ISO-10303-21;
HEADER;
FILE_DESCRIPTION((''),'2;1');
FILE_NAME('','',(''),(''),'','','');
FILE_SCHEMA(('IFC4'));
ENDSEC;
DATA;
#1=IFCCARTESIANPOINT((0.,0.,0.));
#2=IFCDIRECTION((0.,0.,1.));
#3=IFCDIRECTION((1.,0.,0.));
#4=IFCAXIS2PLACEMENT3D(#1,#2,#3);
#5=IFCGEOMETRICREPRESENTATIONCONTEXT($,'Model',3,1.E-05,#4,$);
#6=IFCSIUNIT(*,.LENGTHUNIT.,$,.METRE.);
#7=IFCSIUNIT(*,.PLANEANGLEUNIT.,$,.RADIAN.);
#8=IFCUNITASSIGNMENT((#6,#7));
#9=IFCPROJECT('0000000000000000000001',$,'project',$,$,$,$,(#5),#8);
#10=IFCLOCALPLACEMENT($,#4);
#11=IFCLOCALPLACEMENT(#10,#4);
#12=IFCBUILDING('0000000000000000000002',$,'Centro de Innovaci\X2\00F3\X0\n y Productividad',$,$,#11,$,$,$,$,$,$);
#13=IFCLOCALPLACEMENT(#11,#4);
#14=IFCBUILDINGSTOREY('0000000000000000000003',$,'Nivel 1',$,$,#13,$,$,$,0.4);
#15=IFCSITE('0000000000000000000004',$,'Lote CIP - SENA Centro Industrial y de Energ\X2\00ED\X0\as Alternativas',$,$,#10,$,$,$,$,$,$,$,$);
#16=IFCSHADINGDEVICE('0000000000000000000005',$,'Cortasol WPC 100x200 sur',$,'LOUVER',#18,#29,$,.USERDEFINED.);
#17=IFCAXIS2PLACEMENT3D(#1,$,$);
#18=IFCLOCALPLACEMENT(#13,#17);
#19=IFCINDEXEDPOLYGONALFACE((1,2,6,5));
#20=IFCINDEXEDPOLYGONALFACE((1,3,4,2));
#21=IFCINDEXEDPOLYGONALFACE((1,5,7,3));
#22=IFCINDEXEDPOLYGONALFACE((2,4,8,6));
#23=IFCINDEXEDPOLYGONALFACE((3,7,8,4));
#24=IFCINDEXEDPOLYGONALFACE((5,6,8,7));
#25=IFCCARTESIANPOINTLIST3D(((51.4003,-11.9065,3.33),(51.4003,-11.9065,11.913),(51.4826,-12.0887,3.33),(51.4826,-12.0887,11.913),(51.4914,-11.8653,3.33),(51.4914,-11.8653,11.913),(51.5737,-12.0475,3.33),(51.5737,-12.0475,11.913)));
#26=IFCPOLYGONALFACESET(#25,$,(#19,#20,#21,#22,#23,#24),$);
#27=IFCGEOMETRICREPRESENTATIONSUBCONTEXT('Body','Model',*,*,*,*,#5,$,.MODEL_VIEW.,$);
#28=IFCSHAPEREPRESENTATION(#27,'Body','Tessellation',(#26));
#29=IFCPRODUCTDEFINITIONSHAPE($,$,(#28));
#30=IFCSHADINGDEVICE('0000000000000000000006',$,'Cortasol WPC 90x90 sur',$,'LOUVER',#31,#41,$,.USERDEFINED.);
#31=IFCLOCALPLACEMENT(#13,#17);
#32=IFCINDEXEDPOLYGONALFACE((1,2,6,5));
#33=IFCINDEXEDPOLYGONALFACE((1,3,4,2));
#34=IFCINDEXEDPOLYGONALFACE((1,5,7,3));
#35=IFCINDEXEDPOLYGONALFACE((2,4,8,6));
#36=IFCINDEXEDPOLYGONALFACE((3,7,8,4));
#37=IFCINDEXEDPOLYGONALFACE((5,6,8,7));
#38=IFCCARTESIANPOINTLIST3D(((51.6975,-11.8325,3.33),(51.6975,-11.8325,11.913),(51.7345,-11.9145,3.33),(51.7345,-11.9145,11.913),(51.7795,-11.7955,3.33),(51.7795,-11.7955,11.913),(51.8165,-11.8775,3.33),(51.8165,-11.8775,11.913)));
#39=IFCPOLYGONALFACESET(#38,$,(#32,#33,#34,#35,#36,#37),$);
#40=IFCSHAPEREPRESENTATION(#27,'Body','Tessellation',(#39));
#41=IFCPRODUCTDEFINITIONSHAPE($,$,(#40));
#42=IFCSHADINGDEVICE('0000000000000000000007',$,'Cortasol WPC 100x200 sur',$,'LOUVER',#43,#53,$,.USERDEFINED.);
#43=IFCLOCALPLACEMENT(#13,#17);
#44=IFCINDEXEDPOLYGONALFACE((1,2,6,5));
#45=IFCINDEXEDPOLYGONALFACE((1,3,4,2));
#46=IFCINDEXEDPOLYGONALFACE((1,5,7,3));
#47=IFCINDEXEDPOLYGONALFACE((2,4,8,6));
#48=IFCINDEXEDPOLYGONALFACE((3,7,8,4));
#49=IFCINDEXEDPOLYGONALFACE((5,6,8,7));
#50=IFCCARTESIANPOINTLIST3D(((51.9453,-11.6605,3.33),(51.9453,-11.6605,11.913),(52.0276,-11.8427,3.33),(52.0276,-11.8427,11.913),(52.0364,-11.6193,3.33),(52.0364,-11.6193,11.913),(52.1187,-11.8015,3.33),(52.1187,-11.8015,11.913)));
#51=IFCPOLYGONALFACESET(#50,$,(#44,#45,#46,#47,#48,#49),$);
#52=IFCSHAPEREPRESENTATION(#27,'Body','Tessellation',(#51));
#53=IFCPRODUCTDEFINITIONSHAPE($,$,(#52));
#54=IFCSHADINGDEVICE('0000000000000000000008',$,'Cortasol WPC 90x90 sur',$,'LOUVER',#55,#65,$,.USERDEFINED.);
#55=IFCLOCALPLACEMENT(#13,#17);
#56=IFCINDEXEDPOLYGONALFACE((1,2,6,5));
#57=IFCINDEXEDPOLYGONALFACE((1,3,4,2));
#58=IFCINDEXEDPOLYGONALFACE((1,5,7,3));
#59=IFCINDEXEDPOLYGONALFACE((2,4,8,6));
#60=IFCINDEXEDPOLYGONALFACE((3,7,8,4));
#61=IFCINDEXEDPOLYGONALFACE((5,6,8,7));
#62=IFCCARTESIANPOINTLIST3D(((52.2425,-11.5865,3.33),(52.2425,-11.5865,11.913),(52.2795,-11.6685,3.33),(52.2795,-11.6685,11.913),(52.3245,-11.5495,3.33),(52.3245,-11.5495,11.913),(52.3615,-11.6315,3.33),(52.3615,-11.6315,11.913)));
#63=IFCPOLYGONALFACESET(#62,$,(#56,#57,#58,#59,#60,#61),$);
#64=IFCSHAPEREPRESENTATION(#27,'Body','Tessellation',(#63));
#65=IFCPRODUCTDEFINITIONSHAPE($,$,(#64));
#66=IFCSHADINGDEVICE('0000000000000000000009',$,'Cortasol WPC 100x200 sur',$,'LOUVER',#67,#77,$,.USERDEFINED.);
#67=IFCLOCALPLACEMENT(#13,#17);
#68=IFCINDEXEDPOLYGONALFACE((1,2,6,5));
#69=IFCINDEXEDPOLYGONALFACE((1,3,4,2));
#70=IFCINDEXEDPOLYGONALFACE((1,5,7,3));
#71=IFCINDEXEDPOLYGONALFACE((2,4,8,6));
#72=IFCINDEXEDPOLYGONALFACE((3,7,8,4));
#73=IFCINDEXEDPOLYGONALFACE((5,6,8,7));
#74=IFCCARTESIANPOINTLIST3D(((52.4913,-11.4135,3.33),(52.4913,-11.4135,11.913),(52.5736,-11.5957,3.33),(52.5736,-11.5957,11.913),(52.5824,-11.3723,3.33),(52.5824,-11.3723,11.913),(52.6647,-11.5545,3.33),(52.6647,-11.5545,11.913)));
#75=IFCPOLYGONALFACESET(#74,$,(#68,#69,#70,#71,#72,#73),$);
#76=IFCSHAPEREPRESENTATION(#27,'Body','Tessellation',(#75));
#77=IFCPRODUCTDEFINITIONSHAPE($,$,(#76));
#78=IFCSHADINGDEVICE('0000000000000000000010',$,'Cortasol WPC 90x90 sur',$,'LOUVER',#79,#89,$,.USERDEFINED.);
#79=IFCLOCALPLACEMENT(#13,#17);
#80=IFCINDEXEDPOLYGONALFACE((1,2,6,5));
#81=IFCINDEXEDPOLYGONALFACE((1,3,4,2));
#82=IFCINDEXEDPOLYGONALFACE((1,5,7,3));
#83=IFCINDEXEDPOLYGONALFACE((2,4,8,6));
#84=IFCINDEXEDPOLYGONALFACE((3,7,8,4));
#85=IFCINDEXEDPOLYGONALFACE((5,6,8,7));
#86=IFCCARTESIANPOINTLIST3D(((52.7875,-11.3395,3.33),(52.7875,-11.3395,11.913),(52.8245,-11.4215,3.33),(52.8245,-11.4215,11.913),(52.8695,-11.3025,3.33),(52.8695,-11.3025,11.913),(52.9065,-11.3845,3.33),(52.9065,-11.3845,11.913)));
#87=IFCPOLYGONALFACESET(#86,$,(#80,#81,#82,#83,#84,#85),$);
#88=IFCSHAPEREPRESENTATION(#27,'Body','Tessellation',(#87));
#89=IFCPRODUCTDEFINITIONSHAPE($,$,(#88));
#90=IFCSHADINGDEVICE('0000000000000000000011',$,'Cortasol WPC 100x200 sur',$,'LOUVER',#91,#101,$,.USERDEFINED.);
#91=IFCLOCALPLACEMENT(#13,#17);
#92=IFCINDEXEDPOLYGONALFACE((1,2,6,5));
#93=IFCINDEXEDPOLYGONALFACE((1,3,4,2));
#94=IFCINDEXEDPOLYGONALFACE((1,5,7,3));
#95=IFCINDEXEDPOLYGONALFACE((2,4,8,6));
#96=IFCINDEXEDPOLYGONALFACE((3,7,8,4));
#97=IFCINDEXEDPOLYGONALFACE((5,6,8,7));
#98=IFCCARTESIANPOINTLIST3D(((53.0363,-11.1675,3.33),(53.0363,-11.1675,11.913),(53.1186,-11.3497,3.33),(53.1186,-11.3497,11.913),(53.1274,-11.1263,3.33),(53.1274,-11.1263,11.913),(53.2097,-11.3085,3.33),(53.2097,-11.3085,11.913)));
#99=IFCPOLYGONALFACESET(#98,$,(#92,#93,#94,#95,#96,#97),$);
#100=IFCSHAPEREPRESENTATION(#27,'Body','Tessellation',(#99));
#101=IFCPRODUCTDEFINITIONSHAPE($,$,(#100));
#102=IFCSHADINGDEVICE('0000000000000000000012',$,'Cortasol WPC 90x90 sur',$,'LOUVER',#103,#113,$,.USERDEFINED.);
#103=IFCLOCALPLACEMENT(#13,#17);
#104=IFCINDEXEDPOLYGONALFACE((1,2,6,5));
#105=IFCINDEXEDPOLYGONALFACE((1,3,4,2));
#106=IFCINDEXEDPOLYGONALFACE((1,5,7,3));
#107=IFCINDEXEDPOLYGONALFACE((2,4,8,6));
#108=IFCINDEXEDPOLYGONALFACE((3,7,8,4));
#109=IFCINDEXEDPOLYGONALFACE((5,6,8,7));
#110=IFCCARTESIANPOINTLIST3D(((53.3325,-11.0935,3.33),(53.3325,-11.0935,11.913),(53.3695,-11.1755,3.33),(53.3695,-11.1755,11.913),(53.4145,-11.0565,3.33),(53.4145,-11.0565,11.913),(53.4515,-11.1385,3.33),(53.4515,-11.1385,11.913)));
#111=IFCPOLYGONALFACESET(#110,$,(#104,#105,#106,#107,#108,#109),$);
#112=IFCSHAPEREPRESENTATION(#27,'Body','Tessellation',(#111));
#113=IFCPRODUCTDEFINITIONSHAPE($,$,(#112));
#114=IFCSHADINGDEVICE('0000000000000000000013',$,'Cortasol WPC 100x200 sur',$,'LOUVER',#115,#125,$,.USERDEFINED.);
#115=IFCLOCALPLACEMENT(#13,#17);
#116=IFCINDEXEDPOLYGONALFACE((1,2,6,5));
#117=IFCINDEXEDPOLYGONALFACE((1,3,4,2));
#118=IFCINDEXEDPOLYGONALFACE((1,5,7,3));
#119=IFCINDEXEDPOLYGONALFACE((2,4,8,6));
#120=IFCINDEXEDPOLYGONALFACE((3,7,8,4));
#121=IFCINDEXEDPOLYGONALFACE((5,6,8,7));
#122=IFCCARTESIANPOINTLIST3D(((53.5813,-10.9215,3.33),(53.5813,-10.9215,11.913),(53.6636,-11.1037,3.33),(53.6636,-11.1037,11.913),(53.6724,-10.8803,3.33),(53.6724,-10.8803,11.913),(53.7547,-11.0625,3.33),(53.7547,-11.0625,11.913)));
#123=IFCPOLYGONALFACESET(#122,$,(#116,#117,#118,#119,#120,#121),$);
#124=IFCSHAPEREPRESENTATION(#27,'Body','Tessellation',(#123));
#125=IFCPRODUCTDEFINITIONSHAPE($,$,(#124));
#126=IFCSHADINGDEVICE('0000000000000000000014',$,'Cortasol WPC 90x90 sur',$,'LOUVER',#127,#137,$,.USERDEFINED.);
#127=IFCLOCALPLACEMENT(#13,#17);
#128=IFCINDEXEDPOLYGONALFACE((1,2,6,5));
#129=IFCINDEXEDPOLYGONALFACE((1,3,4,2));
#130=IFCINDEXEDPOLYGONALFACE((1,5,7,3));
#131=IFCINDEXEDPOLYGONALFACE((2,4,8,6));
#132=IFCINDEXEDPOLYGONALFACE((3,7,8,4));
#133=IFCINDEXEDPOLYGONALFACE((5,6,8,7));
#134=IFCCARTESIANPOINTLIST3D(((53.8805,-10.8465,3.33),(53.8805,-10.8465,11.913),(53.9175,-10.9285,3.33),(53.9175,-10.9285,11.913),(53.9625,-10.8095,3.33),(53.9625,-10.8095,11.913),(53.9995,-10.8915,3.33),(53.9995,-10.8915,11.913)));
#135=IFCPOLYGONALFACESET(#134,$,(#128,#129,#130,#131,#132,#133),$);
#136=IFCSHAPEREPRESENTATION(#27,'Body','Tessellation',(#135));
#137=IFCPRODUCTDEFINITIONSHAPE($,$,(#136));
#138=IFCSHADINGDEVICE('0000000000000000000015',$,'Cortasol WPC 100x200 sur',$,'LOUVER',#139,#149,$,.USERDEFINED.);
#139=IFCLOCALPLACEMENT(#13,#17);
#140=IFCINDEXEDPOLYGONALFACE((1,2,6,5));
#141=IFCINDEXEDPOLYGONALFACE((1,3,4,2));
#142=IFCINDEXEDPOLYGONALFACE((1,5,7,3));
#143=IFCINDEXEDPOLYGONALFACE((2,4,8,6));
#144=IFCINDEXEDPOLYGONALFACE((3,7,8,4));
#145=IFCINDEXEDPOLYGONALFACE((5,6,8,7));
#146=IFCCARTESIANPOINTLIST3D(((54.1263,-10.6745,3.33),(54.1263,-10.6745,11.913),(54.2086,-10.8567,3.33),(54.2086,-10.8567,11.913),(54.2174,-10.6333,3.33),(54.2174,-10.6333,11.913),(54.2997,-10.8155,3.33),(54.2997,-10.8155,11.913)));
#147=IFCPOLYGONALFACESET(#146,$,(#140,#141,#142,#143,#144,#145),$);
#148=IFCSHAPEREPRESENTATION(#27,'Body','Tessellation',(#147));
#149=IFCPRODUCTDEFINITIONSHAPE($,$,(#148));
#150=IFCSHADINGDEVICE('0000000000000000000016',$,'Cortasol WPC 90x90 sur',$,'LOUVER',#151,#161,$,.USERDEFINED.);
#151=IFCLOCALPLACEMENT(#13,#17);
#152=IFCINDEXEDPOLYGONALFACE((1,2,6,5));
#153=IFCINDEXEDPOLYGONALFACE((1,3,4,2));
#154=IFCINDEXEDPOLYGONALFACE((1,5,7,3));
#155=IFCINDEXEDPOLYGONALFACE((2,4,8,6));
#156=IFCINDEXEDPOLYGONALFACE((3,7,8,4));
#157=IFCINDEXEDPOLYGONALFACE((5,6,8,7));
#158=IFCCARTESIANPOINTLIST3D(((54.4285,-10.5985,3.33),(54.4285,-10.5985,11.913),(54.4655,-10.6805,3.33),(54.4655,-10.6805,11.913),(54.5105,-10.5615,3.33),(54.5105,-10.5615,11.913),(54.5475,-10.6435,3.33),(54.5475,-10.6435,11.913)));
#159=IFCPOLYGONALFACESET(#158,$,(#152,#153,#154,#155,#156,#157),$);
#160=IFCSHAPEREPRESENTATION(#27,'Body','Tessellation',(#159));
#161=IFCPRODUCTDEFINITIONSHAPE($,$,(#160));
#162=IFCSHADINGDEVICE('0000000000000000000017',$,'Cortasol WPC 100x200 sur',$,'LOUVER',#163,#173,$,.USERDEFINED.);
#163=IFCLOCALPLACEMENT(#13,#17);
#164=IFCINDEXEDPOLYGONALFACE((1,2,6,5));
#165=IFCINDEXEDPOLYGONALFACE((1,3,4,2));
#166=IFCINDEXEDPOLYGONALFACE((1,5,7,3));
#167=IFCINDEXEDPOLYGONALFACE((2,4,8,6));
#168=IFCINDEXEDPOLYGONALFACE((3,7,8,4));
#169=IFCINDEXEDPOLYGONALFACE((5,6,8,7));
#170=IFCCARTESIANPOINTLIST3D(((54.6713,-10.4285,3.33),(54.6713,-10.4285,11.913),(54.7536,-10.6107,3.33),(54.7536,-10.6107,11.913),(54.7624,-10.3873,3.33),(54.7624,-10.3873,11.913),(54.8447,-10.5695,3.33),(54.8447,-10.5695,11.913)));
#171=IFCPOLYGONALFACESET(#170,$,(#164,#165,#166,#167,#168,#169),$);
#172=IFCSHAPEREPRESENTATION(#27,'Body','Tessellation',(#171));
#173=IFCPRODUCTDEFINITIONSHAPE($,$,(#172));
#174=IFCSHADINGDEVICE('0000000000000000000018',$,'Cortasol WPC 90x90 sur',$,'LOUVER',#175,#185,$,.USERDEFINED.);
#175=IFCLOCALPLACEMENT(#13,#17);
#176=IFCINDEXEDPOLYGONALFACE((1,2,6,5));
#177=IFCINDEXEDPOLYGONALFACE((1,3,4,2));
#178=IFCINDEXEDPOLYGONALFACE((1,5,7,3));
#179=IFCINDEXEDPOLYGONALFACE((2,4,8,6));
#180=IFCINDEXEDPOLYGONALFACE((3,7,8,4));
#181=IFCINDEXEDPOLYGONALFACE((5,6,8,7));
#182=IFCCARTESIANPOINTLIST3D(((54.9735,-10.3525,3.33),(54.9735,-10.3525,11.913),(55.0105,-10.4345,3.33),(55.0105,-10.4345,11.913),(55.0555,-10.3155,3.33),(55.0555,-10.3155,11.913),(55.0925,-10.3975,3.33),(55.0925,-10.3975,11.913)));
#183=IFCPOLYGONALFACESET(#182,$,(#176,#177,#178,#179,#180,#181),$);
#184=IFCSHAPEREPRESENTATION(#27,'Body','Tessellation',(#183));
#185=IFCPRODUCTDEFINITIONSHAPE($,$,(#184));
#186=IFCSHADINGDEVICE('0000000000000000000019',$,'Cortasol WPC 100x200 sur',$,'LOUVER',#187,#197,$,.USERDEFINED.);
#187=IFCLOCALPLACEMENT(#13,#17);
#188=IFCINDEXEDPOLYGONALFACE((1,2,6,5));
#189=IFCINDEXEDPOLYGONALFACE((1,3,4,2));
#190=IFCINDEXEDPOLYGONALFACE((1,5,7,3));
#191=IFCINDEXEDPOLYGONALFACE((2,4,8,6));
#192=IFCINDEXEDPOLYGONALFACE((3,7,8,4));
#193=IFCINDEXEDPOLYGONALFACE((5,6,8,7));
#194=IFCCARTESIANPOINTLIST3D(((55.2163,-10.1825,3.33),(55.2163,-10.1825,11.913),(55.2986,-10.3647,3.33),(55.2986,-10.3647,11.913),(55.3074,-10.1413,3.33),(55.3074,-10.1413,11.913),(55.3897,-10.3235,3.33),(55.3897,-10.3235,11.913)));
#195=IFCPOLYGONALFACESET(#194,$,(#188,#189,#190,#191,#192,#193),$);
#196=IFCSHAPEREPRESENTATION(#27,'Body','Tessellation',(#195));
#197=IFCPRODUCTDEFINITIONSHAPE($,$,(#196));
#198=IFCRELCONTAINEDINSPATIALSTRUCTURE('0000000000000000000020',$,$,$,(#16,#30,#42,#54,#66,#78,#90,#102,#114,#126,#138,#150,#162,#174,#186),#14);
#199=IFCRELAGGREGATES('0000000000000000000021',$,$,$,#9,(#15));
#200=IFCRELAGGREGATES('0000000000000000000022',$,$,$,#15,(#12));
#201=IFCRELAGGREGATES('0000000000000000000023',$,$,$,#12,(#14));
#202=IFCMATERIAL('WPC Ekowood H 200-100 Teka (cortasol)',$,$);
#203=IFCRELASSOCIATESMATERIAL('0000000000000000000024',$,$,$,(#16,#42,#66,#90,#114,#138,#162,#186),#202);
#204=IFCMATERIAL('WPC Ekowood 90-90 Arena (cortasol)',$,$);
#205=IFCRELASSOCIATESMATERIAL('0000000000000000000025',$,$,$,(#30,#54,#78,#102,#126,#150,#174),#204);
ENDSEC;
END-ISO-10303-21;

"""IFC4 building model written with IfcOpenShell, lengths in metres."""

from ifc_helpers import new_model, si_unit, frame, origin_with_axes, place, context, subcontext, project, spatial, polyline, outline, extrude, material, element, save


model = new_model("IFC4")

# Units and contexts
model_context = context("Model", 3, precision=1e-05, world=origin_with_axes())
body_context = subcontext(model_context, "Body", "Model", "MODEL_VIEW")
ifc_project = project(units=[si_unit("LENGTHUNIT", "METRE"), si_unit("PLANEANGLEUNIT", "RADIAN")], contexts=[model_context])

# Site, building, storey
site_placement = place(None, origin_with_axes())
site = spatial("IfcSite", under=ifc_project, at=site_placement, Name="Lote CIP - SENA Centro Industrial y de Energías Alternativas")
building_placement = place(site_placement, origin_with_axes())
building = spatial("IfcBuilding", under=site, at=building_placement, Name="Centro de Innovación y Productividad")
storey_placement = place(building_placement, origin_with_axes())
storey = spatial("IfcBuildingStorey", under=building, at=storey_placement, Name="Nivel 1", Elevation=0.4)

# Shading devices
ifc_material_1 = material(Name="WPC Ekowood H 200-100 Teka (cortasol)")
shading_device_1_placement = place(storey_placement, origin_with_axes())
element("IfcShadingDevice", 1, at=shading_device_1_placement, inside=storey, material=ifc_material_1, Name="Cortasol WPC 100x200 sur", ObjectType="LOUVER", PredefinedType="USERDEFINED", context=body_context, shape_type="SweptSolid", body=[
    extrude(outline(polyline([(51.4826, -12.0887), (51.4003, -11.9065), (51.4914, -11.8653), (51.5737, -12.0475), (51.4826, -12.0887)])), frame((0.0, 0.0, 3.33)), (0.0, 0.0, 1.0), 8.583),
])
ifc_material_2 = material(Name="WPC Ekowood 90-90 Arena (cortasol)")
shading_device_2_placement = place(storey_placement, origin_with_axes())
element("IfcShadingDevice", 2, at=shading_device_2_placement, inside=storey, material=ifc_material_2, Name="Cortasol WPC 90x90 sur", ObjectType="LOUVER", PredefinedType="USERDEFINED", context=body_context, shape_type="SweptSolid", body=[
    extrude(outline(polyline([(51.7345, -11.9145), (51.6975, -11.8325), (51.7795, -11.7955), (51.8165, -11.8775), (51.7345, -11.9145)])), frame((0.0, 0.0, 3.33)), (0.0, 0.0, 1.0), 8.583),
])
shading_device_3_placement = place(storey_placement, origin_with_axes())
element("IfcShadingDevice", 3, at=shading_device_3_placement, inside=storey, material=ifc_material_1, Name="Cortasol WPC 100x200 sur", ObjectType="LOUVER", PredefinedType="USERDEFINED", context=body_context, shape_type="SweptSolid", body=[
    extrude(outline(polyline([(52.0276, -11.8427), (51.9453, -11.6605), (52.0364, -11.6193), (52.1187, -11.8015), (52.0276, -11.8427)])), frame((0.0, 0.0, 3.33)), (0.0, 0.0, 1.0), 8.583),
])
shading_device_4_placement = place(storey_placement, origin_with_axes())
element("IfcShadingDevice", 4, at=shading_device_4_placement, inside=storey, material=ifc_material_2, Name="Cortasol WPC 90x90 sur", ObjectType="LOUVER", PredefinedType="USERDEFINED", context=body_context, shape_type="SweptSolid", body=[
    extrude(outline(polyline([(52.2795, -11.6685), (52.2425, -11.5865), (52.3245, -11.5495), (52.3615, -11.6315), (52.2795, -11.6685)])), frame((0.0, 0.0, 3.33)), (0.0, 0.0, 1.0), 8.583),
])
shading_device_5_placement = place(storey_placement, origin_with_axes())
element("IfcShadingDevice", 5, at=shading_device_5_placement, inside=storey, material=ifc_material_1, Name="Cortasol WPC 100x200 sur", ObjectType="LOUVER", PredefinedType="USERDEFINED", context=body_context, shape_type="SweptSolid", body=[
    extrude(outline(polyline([(52.5736, -11.5957), (52.4913, -11.4135), (52.5824, -11.3723), (52.6647, -11.5545), (52.5736, -11.5957)])), frame((0.0, 0.0, 3.33)), (0.0, 0.0, 1.0), 8.583),
])
shading_device_6_placement = place(storey_placement, origin_with_axes())
element("IfcShadingDevice", 6, at=shading_device_6_placement, inside=storey, material=ifc_material_2, Name="Cortasol WPC 90x90 sur", ObjectType="LOUVER", PredefinedType="USERDEFINED", context=body_context, shape_type="SweptSolid", body=[
    extrude(outline(polyline([(52.8245, -11.4215), (52.7875, -11.3395), (52.8695, -11.3025), (52.9065, -11.3845), (52.8245, -11.4215)])), frame((0.0, 0.0, 3.33)), (0.0, 0.0, 1.0), 8.583),
])
shading_device_7_placement = place(storey_placement, origin_with_axes())
element("IfcShadingDevice", 7, at=shading_device_7_placement, inside=storey, material=ifc_material_1, Name="Cortasol WPC 100x200 sur", ObjectType="LOUVER", PredefinedType="USERDEFINED", context=body_context, shape_type="SweptSolid", body=[
    extrude(outline(polyline([(53.1186, -11.3497), (53.0363, -11.1675), (53.1274, -11.1263), (53.2097, -11.3085), (53.1186, -11.3497)])), frame((0.0, 0.0, 3.33)), (0.0, 0.0, 1.0), 8.583),
])
shading_device_8_placement = place(storey_placement, origin_with_axes())
element("IfcShadingDevice", 8, at=shading_device_8_placement, inside=storey, material=ifc_material_2, Name="Cortasol WPC 90x90 sur", ObjectType="LOUVER", PredefinedType="USERDEFINED", context=body_context, shape_type="SweptSolid", body=[
    extrude(outline(polyline([(53.3695, -11.1755), (53.3325, -11.0935), (53.4145, -11.0565), (53.4515, -11.1385), (53.3695, -11.1755)])), frame((0.0, 0.0, 3.33)), (0.0, 0.0, 1.0), 8.583),
])
shading_device_9_placement = place(storey_placement, origin_with_axes())
element("IfcShadingDevice", 9, at=shading_device_9_placement, inside=storey, material=ifc_material_1, Name="Cortasol WPC 100x200 sur", ObjectType="LOUVER", PredefinedType="USERDEFINED", context=body_context, shape_type="SweptSolid", body=[
    extrude(outline(polyline([(53.6636, -11.1037), (53.5813, -10.9215), (53.6724, -10.8803), (53.7547, -11.0625), (53.6636, -11.1037)])), frame((0.0, 0.0, 3.33)), (0.0, 0.0, 1.0), 8.583),
])
shading_device_10_placement = place(storey_placement, origin_with_axes())
element("IfcShadingDevice", 10, at=shading_device_10_placement, inside=storey, material=ifc_material_2, Name="Cortasol WPC 90x90 sur", ObjectType="LOUVER", PredefinedType="USERDEFINED", context=body_context, shape_type="SweptSolid", body=[
    extrude(outline(polyline([(53.9175, -10.9285), (53.8805, -10.8465), (53.9625, -10.8095), (53.9995, -10.8915), (53.9175, -10.9285)])), frame((0.0, 0.0, 3.33)), (0.0, 0.0, 1.0), 8.583),
])
shading_device_11_placement = place(storey_placement, origin_with_axes())
element("IfcShadingDevice", 11, at=shading_device_11_placement, inside=storey, material=ifc_material_1, Name="Cortasol WPC 100x200 sur", ObjectType="LOUVER", PredefinedType="USERDEFINED", context=body_context, shape_type="SweptSolid", body=[
    extrude(outline(polyline([(54.2086, -10.8567), (54.1263, -10.6745), (54.2174, -10.6333), (54.2997, -10.8155), (54.2086, -10.8567)])), frame((0.0, 0.0, 3.33)), (0.0, 0.0, 1.0), 8.583),
])
shading_device_12_placement = place(storey_placement, origin_with_axes())
element("IfcShadingDevice", 12, at=shading_device_12_placement, inside=storey, material=ifc_material_2, Name="Cortasol WPC 90x90 sur", ObjectType="LOUVER", PredefinedType="USERDEFINED", context=body_context, shape_type="SweptSolid", body=[
    extrude(outline(polyline([(54.4655, -10.6805), (54.4285, -10.5985), (54.5105, -10.5615), (54.5475, -10.6435), (54.4655, -10.6805)])), frame((0.0, 0.0, 3.33)), (0.0, 0.0, 1.0), 8.583),
])
shading_device_13_placement = place(storey_placement, origin_with_axes())
element("IfcShadingDevice", 13, at=shading_device_13_placement, inside=storey, material=ifc_material_1, Name="Cortasol WPC 100x200 sur", ObjectType="LOUVER", PredefinedType="USERDEFINED", context=body_context, shape_type="SweptSolid", body=[
    extrude(outline(polyline([(54.7536, -10.6107), (54.6713, -10.4285), (54.7624, -10.3873), (54.8447, -10.5695), (54.7536, -10.6107)])), frame((0.0, 0.0, 3.33)), (0.0, 0.0, 1.0), 8.583),
])
shading_device_14_placement = place(storey_placement, origin_with_axes())
element("IfcShadingDevice", 14, at=shading_device_14_placement, inside=storey, material=ifc_material_2, Name="Cortasol WPC 90x90 sur", ObjectType="LOUVER", PredefinedType="USERDEFINED", context=body_context, shape_type="SweptSolid", body=[
    extrude(outline(polyline([(55.0105, -10.4345), (54.9735, -10.3525), (55.0555, -10.3155), (55.0925, -10.3975), (55.0105, -10.4345)])), frame((0.0, 0.0, 3.33)), (0.0, 0.0, 1.0), 8.583),
])
shading_device_15_placement = place(storey_placement, origin_with_axes())
element("IfcShadingDevice", 15, at=shading_device_15_placement, inside=storey, material=ifc_material_1, Name="Cortasol WPC 100x200 sur", ObjectType="LOUVER", PredefinedType="USERDEFINED", context=body_context, shape_type="SweptSolid", body=[
    extrude(outline(polyline([(55.2986, -10.3647), (55.2163, -10.1825), (55.3074, -10.1413), (55.3897, -10.3235), (55.2986, -10.3647)])), frame((0.0, 0.0, 3.33)), (0.0, 0.0, 1.0), 8.583),
])

save(model, "model.ifc")
